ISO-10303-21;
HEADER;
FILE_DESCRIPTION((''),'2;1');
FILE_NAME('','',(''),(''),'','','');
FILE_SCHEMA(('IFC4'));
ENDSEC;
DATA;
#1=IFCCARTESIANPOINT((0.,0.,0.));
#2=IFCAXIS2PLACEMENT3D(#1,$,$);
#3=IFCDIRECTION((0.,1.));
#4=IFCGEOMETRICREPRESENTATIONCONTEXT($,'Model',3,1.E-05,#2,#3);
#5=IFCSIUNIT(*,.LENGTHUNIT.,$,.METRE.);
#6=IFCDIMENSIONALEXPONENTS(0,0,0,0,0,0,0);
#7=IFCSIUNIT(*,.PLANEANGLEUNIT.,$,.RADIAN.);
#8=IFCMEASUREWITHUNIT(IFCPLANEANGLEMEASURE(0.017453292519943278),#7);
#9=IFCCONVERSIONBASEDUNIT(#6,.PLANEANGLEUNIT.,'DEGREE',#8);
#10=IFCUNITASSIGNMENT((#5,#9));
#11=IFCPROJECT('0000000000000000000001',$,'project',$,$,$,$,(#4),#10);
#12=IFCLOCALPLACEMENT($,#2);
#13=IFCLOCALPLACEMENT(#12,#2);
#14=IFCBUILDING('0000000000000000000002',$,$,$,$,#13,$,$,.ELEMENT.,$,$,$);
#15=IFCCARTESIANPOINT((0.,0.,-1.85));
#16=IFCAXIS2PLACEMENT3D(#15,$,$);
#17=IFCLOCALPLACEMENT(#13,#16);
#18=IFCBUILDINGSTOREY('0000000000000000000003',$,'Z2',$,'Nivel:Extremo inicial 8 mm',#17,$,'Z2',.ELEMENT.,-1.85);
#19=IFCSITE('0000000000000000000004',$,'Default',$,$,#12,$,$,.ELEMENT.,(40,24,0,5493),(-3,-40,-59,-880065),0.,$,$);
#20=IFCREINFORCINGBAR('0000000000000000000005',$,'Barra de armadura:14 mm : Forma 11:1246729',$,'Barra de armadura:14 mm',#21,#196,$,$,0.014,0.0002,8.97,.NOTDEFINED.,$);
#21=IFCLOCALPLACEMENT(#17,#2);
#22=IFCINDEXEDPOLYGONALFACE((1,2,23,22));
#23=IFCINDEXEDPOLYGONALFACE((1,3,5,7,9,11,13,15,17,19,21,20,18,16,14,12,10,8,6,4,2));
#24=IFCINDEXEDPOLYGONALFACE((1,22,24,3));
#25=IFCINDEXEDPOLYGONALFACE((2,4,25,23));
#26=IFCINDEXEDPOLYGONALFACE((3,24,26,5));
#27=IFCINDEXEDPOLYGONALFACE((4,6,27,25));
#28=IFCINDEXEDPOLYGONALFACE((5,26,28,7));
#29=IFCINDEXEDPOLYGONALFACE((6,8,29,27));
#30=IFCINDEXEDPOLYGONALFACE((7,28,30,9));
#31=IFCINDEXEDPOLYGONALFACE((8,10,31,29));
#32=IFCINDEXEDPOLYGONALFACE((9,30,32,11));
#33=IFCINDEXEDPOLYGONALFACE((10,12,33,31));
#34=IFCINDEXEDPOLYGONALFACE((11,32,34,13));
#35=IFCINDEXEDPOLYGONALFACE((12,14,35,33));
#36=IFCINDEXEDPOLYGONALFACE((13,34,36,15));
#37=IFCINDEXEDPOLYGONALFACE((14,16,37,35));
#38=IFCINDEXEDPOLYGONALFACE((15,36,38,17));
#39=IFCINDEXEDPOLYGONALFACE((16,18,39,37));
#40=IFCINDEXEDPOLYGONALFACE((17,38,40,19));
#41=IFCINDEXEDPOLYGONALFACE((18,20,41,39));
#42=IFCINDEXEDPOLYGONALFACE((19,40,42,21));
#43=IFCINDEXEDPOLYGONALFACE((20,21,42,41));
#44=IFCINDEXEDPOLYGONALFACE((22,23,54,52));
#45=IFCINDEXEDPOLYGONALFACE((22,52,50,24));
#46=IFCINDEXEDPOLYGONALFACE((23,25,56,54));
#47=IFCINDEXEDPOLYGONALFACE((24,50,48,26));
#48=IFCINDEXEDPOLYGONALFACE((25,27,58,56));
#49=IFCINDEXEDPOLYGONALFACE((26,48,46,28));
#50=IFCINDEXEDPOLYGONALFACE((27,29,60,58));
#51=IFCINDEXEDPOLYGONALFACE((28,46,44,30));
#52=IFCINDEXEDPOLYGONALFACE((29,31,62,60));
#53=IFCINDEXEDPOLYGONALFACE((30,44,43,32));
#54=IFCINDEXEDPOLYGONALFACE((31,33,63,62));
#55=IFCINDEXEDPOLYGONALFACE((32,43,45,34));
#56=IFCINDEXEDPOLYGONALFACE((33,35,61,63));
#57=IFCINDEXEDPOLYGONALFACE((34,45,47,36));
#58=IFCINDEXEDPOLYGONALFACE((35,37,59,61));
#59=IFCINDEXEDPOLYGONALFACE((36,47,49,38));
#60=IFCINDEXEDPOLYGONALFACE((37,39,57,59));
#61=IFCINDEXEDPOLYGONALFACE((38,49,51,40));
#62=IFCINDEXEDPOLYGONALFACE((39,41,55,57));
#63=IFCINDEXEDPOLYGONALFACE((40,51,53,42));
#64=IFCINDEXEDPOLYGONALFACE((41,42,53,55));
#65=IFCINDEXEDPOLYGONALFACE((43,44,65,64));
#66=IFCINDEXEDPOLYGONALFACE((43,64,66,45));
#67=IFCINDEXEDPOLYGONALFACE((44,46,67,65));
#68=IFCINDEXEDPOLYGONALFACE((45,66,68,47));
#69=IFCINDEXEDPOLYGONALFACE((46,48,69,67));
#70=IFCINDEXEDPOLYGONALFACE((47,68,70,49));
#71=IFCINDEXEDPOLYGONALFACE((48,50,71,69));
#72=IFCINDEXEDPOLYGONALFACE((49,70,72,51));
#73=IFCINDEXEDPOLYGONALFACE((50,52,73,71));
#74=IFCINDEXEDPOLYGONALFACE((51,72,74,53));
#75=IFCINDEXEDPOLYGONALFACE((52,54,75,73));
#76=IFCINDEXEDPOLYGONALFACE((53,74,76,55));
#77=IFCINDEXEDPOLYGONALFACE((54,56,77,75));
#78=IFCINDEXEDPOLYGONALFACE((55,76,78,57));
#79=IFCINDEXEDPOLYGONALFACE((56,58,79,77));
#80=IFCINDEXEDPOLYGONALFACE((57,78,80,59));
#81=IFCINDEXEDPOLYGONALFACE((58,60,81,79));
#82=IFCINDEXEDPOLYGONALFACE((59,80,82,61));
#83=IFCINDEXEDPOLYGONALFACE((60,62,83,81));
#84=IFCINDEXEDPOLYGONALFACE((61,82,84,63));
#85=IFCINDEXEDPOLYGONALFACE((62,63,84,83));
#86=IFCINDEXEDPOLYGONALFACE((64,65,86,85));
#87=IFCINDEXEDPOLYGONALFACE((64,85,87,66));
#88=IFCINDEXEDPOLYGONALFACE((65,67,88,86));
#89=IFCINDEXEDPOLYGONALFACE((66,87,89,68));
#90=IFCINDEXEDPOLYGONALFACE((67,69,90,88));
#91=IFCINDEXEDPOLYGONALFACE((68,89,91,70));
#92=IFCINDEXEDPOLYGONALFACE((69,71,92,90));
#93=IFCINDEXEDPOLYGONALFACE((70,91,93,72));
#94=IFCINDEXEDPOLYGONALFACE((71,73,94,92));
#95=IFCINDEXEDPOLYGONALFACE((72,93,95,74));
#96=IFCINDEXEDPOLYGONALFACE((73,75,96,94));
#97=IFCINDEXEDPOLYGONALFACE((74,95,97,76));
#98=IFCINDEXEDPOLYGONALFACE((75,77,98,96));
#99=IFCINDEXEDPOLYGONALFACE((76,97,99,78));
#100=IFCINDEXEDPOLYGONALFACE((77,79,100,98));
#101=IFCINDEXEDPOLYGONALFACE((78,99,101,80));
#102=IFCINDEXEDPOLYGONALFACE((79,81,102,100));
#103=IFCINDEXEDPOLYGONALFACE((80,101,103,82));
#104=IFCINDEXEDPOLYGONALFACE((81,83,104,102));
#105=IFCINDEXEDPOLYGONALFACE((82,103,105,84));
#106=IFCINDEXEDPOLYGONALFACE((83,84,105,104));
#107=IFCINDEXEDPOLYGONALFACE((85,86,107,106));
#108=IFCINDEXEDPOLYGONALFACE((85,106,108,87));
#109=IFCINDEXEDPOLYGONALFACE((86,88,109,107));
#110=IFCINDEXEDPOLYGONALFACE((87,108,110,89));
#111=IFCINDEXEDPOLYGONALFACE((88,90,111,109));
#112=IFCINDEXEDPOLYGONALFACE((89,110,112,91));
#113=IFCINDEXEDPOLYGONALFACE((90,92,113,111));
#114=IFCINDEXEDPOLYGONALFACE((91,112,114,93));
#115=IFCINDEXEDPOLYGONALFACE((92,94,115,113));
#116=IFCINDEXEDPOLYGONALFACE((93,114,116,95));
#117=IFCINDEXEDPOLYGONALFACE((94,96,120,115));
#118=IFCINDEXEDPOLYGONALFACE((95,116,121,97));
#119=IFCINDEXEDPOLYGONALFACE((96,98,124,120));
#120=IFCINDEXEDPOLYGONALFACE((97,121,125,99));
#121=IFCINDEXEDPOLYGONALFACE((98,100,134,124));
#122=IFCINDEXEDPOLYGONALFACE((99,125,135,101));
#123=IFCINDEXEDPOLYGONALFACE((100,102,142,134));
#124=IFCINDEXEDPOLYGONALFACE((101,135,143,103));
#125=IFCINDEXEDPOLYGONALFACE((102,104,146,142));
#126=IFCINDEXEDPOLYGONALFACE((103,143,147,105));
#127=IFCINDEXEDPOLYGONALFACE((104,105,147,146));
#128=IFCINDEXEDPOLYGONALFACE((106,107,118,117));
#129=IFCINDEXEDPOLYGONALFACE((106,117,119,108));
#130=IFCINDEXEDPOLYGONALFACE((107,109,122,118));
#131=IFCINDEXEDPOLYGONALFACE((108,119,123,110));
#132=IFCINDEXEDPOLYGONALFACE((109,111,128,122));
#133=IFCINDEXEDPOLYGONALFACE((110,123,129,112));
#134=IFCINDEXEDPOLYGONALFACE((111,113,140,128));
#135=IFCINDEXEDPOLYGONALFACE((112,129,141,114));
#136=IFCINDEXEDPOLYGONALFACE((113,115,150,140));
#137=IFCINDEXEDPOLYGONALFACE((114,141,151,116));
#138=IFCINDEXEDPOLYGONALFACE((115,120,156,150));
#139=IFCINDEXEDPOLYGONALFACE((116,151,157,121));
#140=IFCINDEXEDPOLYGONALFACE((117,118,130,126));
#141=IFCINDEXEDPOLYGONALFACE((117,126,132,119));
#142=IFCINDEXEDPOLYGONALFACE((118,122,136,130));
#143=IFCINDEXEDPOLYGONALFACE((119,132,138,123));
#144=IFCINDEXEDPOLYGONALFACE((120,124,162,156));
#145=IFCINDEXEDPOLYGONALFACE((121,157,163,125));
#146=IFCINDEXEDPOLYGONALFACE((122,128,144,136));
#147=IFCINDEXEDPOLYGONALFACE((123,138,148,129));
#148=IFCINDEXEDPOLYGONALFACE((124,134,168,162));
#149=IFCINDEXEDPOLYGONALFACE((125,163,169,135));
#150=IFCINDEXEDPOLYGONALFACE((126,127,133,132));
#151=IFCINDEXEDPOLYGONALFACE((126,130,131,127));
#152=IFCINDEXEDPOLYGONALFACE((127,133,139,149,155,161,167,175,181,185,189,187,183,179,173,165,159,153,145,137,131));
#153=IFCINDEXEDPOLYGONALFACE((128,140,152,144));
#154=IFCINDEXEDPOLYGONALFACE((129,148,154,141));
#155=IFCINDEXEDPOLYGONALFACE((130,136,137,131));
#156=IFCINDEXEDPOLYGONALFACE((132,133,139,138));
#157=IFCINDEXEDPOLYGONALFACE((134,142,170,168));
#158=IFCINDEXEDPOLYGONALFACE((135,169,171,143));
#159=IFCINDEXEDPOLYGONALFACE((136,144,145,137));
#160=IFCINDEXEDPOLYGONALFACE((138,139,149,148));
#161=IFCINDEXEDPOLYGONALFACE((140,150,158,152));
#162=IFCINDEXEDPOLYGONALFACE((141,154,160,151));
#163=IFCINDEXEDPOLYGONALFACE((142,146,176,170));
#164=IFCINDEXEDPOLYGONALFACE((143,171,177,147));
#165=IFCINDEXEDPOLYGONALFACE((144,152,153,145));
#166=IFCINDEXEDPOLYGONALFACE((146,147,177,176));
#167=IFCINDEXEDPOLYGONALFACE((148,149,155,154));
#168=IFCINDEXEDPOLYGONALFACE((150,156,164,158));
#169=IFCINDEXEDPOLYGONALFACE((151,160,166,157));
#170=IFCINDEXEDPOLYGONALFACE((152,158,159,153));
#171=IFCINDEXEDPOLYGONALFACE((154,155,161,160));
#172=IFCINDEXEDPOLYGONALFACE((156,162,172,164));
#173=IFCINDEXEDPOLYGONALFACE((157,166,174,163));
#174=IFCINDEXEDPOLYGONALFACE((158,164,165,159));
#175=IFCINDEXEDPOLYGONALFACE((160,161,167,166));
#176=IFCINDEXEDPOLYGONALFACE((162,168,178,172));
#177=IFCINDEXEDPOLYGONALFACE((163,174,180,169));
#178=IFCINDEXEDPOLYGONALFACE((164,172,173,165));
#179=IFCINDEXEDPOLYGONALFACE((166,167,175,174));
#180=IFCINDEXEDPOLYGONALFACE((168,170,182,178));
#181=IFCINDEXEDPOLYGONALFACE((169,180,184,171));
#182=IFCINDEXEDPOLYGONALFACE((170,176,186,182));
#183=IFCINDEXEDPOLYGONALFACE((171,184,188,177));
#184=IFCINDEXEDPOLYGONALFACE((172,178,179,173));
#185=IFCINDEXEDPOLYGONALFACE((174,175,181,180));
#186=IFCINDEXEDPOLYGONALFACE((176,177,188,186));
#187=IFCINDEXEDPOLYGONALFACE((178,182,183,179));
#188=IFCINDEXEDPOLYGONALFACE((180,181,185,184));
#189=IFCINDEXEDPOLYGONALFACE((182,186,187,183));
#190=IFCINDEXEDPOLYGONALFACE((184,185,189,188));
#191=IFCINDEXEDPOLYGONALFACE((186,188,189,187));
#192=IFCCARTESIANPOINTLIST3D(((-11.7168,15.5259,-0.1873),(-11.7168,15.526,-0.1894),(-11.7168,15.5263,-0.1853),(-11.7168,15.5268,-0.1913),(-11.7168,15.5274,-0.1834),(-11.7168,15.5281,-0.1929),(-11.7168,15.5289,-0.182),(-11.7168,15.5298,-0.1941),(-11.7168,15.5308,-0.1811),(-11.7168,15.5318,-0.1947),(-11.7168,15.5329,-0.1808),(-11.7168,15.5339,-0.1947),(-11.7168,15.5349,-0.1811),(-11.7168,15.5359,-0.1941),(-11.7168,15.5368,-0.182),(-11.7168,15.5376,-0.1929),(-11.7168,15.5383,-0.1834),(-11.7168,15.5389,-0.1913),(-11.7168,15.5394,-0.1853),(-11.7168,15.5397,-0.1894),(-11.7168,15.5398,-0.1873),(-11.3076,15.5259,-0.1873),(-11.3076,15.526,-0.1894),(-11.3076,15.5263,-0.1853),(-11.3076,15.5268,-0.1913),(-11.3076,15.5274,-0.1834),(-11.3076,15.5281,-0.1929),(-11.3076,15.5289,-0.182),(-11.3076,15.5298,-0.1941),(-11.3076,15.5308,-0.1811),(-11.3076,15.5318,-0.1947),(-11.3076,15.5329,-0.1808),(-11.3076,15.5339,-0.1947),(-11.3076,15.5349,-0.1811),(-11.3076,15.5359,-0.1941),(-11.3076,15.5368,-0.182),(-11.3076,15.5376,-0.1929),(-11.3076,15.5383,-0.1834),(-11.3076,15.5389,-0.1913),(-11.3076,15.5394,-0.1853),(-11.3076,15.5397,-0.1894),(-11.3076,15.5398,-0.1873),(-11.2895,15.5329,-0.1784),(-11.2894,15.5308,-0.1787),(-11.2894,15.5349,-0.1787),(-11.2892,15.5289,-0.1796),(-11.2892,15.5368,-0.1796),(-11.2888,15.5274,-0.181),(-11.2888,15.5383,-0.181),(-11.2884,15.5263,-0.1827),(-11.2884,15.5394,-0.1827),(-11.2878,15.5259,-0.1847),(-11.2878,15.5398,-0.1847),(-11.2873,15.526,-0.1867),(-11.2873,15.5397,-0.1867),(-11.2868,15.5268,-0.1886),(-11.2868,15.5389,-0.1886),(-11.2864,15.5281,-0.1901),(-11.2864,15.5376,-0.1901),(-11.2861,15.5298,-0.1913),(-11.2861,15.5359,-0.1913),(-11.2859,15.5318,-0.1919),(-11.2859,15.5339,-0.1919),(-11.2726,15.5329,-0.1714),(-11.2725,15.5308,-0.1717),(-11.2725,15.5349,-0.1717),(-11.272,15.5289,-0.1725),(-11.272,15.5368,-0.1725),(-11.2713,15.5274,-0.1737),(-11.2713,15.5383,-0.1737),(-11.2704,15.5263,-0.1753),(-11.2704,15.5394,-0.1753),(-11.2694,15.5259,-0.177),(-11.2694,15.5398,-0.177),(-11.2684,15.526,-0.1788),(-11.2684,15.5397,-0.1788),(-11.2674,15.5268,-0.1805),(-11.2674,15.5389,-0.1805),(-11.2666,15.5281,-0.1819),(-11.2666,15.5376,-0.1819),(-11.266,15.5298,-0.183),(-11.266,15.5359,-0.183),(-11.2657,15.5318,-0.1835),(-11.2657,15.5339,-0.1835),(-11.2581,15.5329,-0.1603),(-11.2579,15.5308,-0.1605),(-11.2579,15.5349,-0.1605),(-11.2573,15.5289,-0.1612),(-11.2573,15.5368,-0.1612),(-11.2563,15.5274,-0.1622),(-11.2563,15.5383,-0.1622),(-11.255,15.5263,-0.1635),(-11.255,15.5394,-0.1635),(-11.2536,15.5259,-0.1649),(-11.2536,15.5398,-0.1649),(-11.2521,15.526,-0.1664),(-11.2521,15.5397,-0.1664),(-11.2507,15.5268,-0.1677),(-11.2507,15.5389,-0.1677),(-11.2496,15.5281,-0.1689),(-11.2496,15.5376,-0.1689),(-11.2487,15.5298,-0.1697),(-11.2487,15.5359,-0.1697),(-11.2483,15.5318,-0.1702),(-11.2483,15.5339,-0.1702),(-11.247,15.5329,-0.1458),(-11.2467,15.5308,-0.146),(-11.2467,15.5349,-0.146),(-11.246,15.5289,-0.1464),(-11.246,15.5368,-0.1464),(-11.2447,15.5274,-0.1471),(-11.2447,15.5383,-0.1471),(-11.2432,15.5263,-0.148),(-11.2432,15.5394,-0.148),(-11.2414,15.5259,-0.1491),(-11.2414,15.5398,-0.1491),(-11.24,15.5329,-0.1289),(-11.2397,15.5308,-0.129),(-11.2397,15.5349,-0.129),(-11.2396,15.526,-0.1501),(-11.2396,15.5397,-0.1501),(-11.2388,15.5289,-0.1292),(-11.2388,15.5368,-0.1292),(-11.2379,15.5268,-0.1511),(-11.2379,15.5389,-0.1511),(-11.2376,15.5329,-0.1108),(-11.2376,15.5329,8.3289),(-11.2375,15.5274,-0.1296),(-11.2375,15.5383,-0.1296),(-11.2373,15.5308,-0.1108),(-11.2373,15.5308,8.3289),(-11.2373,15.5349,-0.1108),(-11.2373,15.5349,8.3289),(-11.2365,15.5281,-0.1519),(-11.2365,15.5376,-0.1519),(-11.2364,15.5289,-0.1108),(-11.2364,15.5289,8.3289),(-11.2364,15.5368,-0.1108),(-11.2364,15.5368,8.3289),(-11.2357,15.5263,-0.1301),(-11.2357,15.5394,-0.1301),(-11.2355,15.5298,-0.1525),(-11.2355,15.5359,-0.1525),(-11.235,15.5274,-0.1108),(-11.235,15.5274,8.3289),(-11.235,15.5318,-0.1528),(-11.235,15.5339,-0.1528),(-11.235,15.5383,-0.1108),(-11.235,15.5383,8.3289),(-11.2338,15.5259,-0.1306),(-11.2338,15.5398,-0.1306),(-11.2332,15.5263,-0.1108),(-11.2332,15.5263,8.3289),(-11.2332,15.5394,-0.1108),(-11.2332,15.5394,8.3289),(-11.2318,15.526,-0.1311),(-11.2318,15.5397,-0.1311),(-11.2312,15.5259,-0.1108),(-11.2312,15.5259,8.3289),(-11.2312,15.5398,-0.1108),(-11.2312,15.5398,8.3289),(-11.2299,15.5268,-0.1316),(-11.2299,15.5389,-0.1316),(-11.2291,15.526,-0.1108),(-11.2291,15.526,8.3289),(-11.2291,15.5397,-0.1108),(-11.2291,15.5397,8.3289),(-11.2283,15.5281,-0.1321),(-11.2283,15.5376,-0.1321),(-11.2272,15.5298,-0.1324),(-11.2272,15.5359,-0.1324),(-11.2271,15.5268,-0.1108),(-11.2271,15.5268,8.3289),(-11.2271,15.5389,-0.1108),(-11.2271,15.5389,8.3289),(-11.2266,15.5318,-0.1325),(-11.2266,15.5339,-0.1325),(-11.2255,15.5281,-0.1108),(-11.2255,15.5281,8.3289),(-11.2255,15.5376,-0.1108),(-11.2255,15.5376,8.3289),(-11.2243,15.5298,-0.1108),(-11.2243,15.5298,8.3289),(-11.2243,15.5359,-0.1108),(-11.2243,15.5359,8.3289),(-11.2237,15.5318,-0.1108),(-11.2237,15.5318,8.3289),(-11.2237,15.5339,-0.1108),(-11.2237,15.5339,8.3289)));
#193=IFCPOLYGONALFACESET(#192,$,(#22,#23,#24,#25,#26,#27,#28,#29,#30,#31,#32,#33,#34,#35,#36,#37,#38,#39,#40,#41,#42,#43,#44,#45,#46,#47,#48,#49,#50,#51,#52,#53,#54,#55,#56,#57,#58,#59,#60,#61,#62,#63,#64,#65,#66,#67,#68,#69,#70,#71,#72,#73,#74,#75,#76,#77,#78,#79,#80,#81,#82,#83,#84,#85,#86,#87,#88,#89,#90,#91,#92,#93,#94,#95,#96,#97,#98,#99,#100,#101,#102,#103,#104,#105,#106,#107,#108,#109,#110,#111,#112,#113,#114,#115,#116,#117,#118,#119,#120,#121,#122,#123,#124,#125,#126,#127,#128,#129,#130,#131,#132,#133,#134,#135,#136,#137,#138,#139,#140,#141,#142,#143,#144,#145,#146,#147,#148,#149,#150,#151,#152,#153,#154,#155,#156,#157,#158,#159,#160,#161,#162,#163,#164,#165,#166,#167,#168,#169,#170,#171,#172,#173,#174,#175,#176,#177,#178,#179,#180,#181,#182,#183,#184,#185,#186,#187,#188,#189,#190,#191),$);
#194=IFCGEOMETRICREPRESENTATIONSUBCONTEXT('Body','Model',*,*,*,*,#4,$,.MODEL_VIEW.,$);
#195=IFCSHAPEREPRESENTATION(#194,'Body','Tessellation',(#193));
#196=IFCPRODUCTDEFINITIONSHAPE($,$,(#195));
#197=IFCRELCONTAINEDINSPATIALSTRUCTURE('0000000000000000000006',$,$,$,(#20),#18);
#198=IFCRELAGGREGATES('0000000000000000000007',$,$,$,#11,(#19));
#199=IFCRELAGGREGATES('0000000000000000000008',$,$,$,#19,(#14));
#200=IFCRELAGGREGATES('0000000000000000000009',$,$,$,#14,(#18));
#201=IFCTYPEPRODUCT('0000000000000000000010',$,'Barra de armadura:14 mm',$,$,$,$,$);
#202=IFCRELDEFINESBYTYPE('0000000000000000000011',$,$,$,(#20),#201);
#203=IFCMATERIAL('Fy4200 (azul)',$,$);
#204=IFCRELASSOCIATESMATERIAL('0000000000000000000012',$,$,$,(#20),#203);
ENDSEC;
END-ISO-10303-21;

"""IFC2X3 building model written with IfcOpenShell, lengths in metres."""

from ifc_helpers import new_model, entity, si_unit, converted_unit, direction, frame, origin, place, context, subcontext, project, spatial, material, type_object, element, save


model = new_model("IFC2X3")

# Units and contexts
model_context = context("Model", 3, precision=1e-05, world=origin(), true_north=direction((0.0, 1.0)))
body_context = subcontext(model_context, "Body", "Model", "MODEL_VIEW")
ifc_project = project(units=[si_unit("LENGTHUNIT", "METRE"), converted_unit("PLANEANGLEUNIT", "DEGREE", entity("IfcPlaneAngleMeasure", 0.017453292519943278), si_unit("PLANEANGLEUNIT", "RADIAN"), dimensions=[0, 0, 0, 0, 0, 0, 0])], contexts=[model_context])

# Site, building, storey
site_placement = place(None, origin())
site = spatial("IfcSite", under=ifc_project, at=site_placement, Name="Default", CompositionType="ELEMENT", RefLatitude=(40, 24, 0, 5493), RefLongitude=(-3, -40, -59, -880065), RefElevation=0.0)
building_placement = place(site_placement, origin())
building = spatial("IfcBuilding", under=site, at=building_placement, CompositionType="ELEMENT")
storey_placement = place(building_placement, frame((0.0, 0.0, -1.85)))
storey = spatial("IfcBuildingStorey", under=building, at=storey_placement, Name="Z2", ObjectType="Nivel:Extremo inicial 8 mm", LongName="Z2", CompositionType="ELEMENT", Elevation=-1.85)

# Reinforcing bar
ifc_material_1 = material(Name="Fy4200 (azul)")
type_product_1 = type_object("IfcTypeProduct", Name="Barra de armadura:14 mm")
reinforcing_bar_1_placement = place(storey_placement, origin())
element("IfcReinforcingBar", 1, at=reinforcing_bar_1_placement, inside=storey, type_object=type_product_1, material=ifc_material_1, Name="Barra de armadura:14 mm : Forma 11:1246729", ObjectType="Barra de armadura:14 mm", BarLength=8.97, BarRole="NOTDEFINED", CrossSectionArea=0.0002, NominalDiameter=0.014, context=body_context, shape_type="AdvancedSweptSolid", body=[
    entity("IfcSweptDiskSolid", entity("IfcCompositeCurve", [entity("IfcCompositeCurveSegment", "CONTINUOUS", True, entity("IfcPolyline", [entity("IfcCartesianPoint", [-11.2306, 15.5329, 8.3289]), entity("IfcCartesianPoint", [-11.2306, 15.5329, -0.1108])])), entity("IfcCompositeCurveSegment", "CONTINUOUS", True, entity("IfcTrimmedCurve", entity("IfcCircle", entity("IfcAxis2Placement3D", entity("IfcCartesianPoint", [-11.3076, 15.5329, -0.1108]), entity("IfcDirection", [0.0, 1.0, 0.0]), entity("IfcDirection", [0.0, 0.0, -1.0])), 0.077), [entity("IfcParameterValue", 270.0)], [entity("IfcParameterValue", 360.0)], True, "PARAMETER")), entity("IfcCompositeCurveSegment", "CONTINUOUS", True, entity("IfcPolyline", [entity("IfcCartesianPoint", [-11.3076, 15.5329, -0.1878]), entity("IfcCartesianPoint", [-11.7168, 15.5329, -0.1878])]))], False), 0.007, None, 0.0, 92.0),
])

save(model, "model.ifc")
